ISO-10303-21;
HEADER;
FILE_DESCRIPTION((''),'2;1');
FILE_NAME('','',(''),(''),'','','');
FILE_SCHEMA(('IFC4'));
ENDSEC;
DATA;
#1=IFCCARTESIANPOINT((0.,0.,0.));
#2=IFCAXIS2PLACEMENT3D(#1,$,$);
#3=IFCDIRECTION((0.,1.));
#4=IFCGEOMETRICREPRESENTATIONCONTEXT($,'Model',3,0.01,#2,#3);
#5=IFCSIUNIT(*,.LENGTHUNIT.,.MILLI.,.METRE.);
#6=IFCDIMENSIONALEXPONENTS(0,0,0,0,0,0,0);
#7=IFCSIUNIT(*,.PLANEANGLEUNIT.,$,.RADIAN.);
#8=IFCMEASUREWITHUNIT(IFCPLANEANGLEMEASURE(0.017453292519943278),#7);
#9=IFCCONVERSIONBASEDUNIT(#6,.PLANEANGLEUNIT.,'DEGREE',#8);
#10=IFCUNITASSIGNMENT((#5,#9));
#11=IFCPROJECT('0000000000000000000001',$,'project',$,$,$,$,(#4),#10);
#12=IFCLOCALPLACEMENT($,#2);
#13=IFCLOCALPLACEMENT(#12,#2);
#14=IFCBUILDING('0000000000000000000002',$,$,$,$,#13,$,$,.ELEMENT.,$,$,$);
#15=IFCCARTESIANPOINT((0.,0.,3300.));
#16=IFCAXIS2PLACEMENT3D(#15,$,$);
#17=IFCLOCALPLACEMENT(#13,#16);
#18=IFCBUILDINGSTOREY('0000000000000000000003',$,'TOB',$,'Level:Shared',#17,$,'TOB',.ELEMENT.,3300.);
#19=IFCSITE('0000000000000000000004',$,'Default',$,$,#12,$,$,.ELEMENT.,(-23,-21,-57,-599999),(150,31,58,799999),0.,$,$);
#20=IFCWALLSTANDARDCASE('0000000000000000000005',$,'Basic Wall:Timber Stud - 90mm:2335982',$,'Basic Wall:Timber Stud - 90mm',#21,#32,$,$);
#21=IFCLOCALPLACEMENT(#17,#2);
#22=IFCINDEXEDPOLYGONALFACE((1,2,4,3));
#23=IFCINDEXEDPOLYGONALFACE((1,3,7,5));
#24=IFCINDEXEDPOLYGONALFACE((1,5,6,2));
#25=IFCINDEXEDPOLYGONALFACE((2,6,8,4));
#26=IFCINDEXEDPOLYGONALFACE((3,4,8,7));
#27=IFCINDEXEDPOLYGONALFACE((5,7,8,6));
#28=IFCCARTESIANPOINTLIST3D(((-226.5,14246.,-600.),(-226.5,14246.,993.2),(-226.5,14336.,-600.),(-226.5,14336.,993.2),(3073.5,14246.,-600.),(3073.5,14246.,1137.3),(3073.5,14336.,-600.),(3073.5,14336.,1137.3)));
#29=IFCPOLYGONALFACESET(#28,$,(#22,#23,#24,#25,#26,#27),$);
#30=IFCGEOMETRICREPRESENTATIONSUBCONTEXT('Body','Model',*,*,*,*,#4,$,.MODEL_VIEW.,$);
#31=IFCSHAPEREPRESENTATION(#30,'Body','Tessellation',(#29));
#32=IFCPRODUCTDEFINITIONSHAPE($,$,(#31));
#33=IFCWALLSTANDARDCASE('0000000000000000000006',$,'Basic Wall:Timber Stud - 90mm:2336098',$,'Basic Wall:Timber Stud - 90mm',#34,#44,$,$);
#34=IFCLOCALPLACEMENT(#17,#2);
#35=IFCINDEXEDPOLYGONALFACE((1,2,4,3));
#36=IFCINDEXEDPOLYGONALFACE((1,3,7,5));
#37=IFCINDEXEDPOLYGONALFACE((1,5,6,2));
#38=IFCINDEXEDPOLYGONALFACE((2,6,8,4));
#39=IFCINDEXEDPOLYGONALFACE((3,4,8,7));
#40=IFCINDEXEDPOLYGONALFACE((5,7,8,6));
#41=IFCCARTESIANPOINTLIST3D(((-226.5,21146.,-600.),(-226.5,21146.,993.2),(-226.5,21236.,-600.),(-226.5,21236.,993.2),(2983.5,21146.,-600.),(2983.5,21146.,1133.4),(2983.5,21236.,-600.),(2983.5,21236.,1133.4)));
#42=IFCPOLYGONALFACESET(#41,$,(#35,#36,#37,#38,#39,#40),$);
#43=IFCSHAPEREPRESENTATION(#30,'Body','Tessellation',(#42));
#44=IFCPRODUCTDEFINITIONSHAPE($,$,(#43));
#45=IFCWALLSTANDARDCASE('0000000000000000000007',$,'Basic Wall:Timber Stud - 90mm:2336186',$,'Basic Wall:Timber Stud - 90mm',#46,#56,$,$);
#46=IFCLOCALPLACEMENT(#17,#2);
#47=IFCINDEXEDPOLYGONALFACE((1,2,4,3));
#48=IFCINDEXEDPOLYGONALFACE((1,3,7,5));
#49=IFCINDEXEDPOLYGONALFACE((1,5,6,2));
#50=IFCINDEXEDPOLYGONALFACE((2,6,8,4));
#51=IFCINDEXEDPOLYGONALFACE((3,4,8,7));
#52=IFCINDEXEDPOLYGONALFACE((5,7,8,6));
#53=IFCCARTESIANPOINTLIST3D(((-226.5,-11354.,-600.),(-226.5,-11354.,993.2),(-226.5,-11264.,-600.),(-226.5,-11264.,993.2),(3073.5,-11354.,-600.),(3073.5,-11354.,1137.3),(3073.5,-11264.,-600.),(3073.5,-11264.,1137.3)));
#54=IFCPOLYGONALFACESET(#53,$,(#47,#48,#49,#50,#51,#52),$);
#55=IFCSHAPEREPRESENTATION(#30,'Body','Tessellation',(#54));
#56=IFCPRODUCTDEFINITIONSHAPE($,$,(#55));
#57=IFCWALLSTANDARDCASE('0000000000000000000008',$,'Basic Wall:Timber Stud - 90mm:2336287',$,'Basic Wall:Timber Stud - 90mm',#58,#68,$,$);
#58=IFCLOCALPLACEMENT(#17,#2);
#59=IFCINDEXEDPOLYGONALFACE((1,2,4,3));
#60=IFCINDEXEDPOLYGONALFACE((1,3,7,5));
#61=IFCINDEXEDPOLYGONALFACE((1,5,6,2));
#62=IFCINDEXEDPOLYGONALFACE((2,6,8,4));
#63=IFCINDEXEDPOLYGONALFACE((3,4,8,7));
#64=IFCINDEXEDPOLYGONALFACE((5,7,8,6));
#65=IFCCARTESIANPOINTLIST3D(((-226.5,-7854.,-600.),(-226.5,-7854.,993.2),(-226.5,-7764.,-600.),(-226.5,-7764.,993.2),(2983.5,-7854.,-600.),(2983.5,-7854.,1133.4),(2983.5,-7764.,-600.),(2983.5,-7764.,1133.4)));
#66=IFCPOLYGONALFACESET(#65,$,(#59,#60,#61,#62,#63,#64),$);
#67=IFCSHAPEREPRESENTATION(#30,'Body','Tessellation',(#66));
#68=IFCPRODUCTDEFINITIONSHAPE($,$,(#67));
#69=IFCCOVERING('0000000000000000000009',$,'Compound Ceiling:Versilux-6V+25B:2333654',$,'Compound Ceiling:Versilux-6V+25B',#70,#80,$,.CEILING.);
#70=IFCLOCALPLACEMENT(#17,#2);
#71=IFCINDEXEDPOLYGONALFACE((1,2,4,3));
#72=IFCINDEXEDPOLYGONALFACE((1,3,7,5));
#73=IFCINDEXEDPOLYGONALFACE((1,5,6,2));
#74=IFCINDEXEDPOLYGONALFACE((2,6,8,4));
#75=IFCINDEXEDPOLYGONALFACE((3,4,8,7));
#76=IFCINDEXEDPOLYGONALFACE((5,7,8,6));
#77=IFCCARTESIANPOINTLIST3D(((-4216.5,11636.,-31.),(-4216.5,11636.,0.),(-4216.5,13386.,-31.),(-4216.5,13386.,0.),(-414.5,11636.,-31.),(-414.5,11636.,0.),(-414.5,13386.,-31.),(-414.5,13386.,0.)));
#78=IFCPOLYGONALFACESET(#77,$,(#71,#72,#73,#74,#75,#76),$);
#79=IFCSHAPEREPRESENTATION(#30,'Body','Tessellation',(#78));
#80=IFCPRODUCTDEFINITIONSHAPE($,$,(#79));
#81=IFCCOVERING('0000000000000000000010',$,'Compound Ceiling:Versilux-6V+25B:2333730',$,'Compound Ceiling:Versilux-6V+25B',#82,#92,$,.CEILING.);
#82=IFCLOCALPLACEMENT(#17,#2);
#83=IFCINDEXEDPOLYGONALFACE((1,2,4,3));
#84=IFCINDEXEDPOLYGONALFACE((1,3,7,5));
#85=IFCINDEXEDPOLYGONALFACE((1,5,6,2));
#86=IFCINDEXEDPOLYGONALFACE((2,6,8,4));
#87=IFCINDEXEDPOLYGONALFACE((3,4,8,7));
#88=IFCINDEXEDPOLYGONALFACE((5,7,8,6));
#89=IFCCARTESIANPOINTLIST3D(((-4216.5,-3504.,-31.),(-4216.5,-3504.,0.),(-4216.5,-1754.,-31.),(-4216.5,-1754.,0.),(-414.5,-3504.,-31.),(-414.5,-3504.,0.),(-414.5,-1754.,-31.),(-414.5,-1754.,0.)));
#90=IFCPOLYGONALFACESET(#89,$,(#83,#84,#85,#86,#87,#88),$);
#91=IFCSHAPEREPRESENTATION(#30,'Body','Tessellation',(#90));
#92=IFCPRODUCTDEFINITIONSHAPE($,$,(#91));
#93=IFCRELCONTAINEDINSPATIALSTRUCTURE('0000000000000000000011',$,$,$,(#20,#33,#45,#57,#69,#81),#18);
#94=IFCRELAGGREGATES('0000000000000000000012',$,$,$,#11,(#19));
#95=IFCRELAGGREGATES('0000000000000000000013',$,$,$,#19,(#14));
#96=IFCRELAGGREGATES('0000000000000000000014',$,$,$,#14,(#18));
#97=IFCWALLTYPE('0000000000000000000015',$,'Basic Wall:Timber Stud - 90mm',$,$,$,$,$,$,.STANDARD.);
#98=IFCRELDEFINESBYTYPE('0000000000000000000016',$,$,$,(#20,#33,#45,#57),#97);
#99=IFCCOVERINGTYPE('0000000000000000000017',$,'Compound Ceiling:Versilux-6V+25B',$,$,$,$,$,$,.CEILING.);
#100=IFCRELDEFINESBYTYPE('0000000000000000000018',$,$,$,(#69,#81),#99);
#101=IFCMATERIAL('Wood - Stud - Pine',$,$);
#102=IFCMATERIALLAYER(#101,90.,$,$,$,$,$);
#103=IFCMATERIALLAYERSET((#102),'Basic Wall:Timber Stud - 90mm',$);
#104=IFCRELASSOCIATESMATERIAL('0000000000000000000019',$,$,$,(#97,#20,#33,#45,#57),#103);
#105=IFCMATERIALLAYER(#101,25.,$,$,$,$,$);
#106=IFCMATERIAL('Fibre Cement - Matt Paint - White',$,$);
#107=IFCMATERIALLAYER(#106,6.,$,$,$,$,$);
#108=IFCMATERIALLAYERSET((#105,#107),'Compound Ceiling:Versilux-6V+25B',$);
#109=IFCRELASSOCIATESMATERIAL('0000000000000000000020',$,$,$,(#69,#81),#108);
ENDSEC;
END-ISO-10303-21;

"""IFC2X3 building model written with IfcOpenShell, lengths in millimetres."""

from ifc_helpers import new_model, entity, si_unit, converted_unit, direction, frame, frame_2d, origin, origin_2d_with_axis, place, context, subcontext, project, spatial, polyline, rectangle, extrude, clip, bounded_halfspace, material, layer, layer_set, layer_usage, type_object, element, save


model = new_model("IFC2X3")

# Units and contexts
model_context = context("Model", 3, precision=0.01, world=origin(), true_north=direction((0.0, 1.0)))
body_context = subcontext(model_context, "Body", "Model", "MODEL_VIEW")
ifc_project = project(units=[si_unit("LENGTHUNIT", "METRE", prefix="MILLI"), converted_unit("PLANEANGLEUNIT", "DEGREE", entity("IfcPlaneAngleMeasure", 0.017453292519943278), si_unit("PLANEANGLEUNIT", "RADIAN"), dimensions=[0, 0, 0, 0, 0, 0, 0])], contexts=[model_context])

# Site, building, storey
site_placement = place(None, origin())
site = spatial("IfcSite", under=ifc_project, at=site_placement, Name="Default", CompositionType="ELEMENT", RefLatitude=(-23, -21, -57, -599999), RefLongitude=(150, 31, 58, 799999), RefElevation=0.0)
building_placement = place(site_placement, origin())
building = spatial("IfcBuilding", under=site, at=building_placement, CompositionType="ELEMENT")
storey_placement = place(building_placement, frame((0.0, 0.0, 3300.0)))
storey = spatial("IfcBuildingStorey", under=building, at=storey_placement, Name="TOB", ObjectType="Level:Shared", LongName="TOB", CompositionType="ELEMENT", Elevation=3300.0)

# Walls
ifc_material_1 = material(Name="Wood - Stud - Pine")
ifc_layer_1 = layer(ifc_material_1, 90.0)
ifc_layer_set_1 = layer_set([ifc_layer_1], Name="Basic Wall:Timber Stud - 90mm")
ifc_layer_usage_1 = layer_usage(ifc_layer_set_1, "AXIS2", "NEGATIVE", 45.0)
wall_type = type_object("IfcWallType", Name="Basic Wall:Timber Stud - 90mm", PredefinedType="STANDARD", material=ifc_layer_set_1)
wall_1_placement = place(storey_placement, frame((-226.5, 14291.0, -600.0)))
element("IfcWallStandardCase", 1, at=wall_1_placement, inside=storey, type_object=wall_type, material=ifc_layer_usage_1, Name="Basic Wall:Timber Stud - 90mm:2335982", ObjectType="Basic Wall:Timber Stud - 90mm", context=body_context, shape_type="Clipping", body=[
    clip(extrude(rectangle(XDim=3300.0, YDim=90.0, at=frame_2d((1650.0, 0.0), x_axis=(-1.0, 0.0))), origin(), (0.0, 0.0, 1.0), 1737.3), bounded_halfspace(frame((0.0, -45.0, 1593.2), z_axis=(-0.043619, 0.0, 0.999048), x_axis=(0.0, -1.0, 0.0)), False, frame((0.0, -45.0, 1593.2)), polyline([(0.0, 0.0), (3300.0, 0.0), (3300.0, 90.0), (3210.0, 90.0), (0.0, 90.0), (0.0, 0.0)]))),
])
ifc_layer_usage_2 = layer_usage(ifc_layer_set_1, "AXIS2", "NEGATIVE", 45.0)
wall_2_placement = place(storey_placement, frame((2983.5, 21191.0, -600.0), z_axis=(0.0, 0.0, 1.0), x_axis=(-1.0, 0.0, 0.0)))
element("IfcWallStandardCase", 2, at=wall_2_placement, inside=storey, type_object=wall_type, material=ifc_layer_usage_2, Name="Basic Wall:Timber Stud - 90mm:2336098", ObjectType="Basic Wall:Timber Stud - 90mm", context=body_context, shape_type="Clipping", body=[
    clip(extrude(rectangle(XDim=3210.0, YDim=90.0, at=frame_2d((1605.0, 0.0), x_axis=(-1.0, 0.0))), origin(), (0.0, 0.0, 1.0), 1733.4), bounded_halfspace(frame((0.0, -45.0, 1733.4), z_axis=(0.043619, 0.0, 0.999048), x_axis=(0.0, 1.0, 0.0)), False, frame((0.0, -45.0, 1733.4)), polyline([(0.0, 0.0), (3210.0, 0.0), (3210.0, 90.0), (0.0, 90.0), (0.0, 0.0)]))),
])
ifc_layer_usage_3 = layer_usage(ifc_layer_set_1, "AXIS2", "NEGATIVE", 45.0)
wall_3_placement = place(storey_placement, frame((-226.5, -11309.0, -600.0)))
element("IfcWallStandardCase", 3, at=wall_3_placement, inside=storey, type_object=wall_type, material=ifc_layer_usage_3, Name="Basic Wall:Timber Stud - 90mm:2336186", ObjectType="Basic Wall:Timber Stud - 90mm", context=body_context, shape_type="Clipping", body=[
    clip(extrude(rectangle(XDim=3300.0, YDim=90.0, at=frame_2d((1650.0, 0.0), x_axis=(-1.0, 0.0))), origin(), (0.0, 0.0, 1.0), 1737.3), bounded_halfspace(frame((0.0, -45.0, 1593.2), z_axis=(-0.043619, 0.0, 0.999048), x_axis=(0.0, -1.0, 0.0)), False, frame((0.0, -45.0, 1593.2)), polyline([(0.0, 0.0), (3300.0, 0.0), (3300.0, 90.0), (3210.0, 90.0), (0.0, 90.0), (0.0, 0.0)]))),
])
ifc_layer_usage_4 = layer_usage(ifc_layer_set_1, "AXIS2", "NEGATIVE", 45.0)
wall_4_placement = place(storey_placement, frame((2983.5, -7809.0, -600.0), z_axis=(0.0, 0.0, 1.0), x_axis=(-1.0, 0.0, 0.0)))
element("IfcWallStandardCase", 4, at=wall_4_placement, inside=storey, type_object=wall_type, material=ifc_layer_usage_4, Name="Basic Wall:Timber Stud - 90mm:2336287", ObjectType="Basic Wall:Timber Stud - 90mm", context=body_context, shape_type="Clipping", body=[
    clip(extrude(rectangle(XDim=3210.0, YDim=90.0, at=frame_2d((1605.0, 0.0), x_axis=(-1.0, 0.0))), origin(), (0.0, 0.0, 1.0), 1733.4), bounded_halfspace(frame((0.0, -45.0, 1733.4), z_axis=(0.043619, 0.0, 0.999048), x_axis=(0.0, 1.0, 0.0)), False, frame((0.0, -45.0, 1733.4)), polyline([(0.0, 0.0), (3210.0, 0.0), (3210.0, 90.0), (0.0, 90.0), (0.0, 0.0)]))),
])

# Coverings
ifc_layer_2 = layer(ifc_material_1, 25.0)
ifc_material_2 = material(Name="Fibre Cement - Matt Paint - White")
ifc_layer_3 = layer(ifc_material_2, 6.0)
ifc_layer_set_2 = layer_set([ifc_layer_2, ifc_layer_3], Name="Compound Ceiling:Versilux-6V+25B")
ifc_layer_usage_5 = layer_usage(ifc_layer_set_2, "AXIS3", "NEGATIVE", 31.0)
covering_type = type_object("IfcCoveringType", Name="Compound Ceiling:Versilux-6V+25B", PredefinedType="CEILING")
covering_1_placement = place(storey_placement, origin())
element("IfcCovering", 5, at=covering_1_placement, inside=storey, type_object=covering_type, material=ifc_layer_usage_5, Name="Compound Ceiling:Versilux-6V+25B:2333654", ObjectType="Compound Ceiling:Versilux-6V+25B", PredefinedType="CEILING", context=body_context, shape_type="SweptSolid", body=[
    extrude(rectangle(XDim=1750.0, YDim=3802.0, at=origin_2d_with_axis()), frame((-2315.5, 12511.0, -31.0), z_axis=(0.0, 0.0, 1.0), x_axis=(0.0, 1.0, 0.0)), (0.0, 0.0, 1.0), 31.0),
])
ifc_layer_usage_6 = layer_usage(ifc_layer_set_2, "AXIS3", "NEGATIVE", 31.0)
covering_2_placement = place(storey_placement, origin())
element("IfcCovering", 6, at=covering_2_placement, inside=storey, type_object=covering_type, material=ifc_layer_usage_6, Name="Compound Ceiling:Versilux-6V+25B:2333730", ObjectType="Compound Ceiling:Versilux-6V+25B", PredefinedType="CEILING", context=body_context, shape_type="SweptSolid", body=[
    extrude(rectangle(XDim=3802.0, YDim=1750.0, at=origin_2d_with_axis()), frame((-2315.5, -2629.0, -31.0), z_axis=(0.0, 0.0, 1.0), x_axis=(-1.0, 0.0, 0.0)), (0.0, 0.0, 1.0), 31.0),
])

save(model, "model.ifc")
